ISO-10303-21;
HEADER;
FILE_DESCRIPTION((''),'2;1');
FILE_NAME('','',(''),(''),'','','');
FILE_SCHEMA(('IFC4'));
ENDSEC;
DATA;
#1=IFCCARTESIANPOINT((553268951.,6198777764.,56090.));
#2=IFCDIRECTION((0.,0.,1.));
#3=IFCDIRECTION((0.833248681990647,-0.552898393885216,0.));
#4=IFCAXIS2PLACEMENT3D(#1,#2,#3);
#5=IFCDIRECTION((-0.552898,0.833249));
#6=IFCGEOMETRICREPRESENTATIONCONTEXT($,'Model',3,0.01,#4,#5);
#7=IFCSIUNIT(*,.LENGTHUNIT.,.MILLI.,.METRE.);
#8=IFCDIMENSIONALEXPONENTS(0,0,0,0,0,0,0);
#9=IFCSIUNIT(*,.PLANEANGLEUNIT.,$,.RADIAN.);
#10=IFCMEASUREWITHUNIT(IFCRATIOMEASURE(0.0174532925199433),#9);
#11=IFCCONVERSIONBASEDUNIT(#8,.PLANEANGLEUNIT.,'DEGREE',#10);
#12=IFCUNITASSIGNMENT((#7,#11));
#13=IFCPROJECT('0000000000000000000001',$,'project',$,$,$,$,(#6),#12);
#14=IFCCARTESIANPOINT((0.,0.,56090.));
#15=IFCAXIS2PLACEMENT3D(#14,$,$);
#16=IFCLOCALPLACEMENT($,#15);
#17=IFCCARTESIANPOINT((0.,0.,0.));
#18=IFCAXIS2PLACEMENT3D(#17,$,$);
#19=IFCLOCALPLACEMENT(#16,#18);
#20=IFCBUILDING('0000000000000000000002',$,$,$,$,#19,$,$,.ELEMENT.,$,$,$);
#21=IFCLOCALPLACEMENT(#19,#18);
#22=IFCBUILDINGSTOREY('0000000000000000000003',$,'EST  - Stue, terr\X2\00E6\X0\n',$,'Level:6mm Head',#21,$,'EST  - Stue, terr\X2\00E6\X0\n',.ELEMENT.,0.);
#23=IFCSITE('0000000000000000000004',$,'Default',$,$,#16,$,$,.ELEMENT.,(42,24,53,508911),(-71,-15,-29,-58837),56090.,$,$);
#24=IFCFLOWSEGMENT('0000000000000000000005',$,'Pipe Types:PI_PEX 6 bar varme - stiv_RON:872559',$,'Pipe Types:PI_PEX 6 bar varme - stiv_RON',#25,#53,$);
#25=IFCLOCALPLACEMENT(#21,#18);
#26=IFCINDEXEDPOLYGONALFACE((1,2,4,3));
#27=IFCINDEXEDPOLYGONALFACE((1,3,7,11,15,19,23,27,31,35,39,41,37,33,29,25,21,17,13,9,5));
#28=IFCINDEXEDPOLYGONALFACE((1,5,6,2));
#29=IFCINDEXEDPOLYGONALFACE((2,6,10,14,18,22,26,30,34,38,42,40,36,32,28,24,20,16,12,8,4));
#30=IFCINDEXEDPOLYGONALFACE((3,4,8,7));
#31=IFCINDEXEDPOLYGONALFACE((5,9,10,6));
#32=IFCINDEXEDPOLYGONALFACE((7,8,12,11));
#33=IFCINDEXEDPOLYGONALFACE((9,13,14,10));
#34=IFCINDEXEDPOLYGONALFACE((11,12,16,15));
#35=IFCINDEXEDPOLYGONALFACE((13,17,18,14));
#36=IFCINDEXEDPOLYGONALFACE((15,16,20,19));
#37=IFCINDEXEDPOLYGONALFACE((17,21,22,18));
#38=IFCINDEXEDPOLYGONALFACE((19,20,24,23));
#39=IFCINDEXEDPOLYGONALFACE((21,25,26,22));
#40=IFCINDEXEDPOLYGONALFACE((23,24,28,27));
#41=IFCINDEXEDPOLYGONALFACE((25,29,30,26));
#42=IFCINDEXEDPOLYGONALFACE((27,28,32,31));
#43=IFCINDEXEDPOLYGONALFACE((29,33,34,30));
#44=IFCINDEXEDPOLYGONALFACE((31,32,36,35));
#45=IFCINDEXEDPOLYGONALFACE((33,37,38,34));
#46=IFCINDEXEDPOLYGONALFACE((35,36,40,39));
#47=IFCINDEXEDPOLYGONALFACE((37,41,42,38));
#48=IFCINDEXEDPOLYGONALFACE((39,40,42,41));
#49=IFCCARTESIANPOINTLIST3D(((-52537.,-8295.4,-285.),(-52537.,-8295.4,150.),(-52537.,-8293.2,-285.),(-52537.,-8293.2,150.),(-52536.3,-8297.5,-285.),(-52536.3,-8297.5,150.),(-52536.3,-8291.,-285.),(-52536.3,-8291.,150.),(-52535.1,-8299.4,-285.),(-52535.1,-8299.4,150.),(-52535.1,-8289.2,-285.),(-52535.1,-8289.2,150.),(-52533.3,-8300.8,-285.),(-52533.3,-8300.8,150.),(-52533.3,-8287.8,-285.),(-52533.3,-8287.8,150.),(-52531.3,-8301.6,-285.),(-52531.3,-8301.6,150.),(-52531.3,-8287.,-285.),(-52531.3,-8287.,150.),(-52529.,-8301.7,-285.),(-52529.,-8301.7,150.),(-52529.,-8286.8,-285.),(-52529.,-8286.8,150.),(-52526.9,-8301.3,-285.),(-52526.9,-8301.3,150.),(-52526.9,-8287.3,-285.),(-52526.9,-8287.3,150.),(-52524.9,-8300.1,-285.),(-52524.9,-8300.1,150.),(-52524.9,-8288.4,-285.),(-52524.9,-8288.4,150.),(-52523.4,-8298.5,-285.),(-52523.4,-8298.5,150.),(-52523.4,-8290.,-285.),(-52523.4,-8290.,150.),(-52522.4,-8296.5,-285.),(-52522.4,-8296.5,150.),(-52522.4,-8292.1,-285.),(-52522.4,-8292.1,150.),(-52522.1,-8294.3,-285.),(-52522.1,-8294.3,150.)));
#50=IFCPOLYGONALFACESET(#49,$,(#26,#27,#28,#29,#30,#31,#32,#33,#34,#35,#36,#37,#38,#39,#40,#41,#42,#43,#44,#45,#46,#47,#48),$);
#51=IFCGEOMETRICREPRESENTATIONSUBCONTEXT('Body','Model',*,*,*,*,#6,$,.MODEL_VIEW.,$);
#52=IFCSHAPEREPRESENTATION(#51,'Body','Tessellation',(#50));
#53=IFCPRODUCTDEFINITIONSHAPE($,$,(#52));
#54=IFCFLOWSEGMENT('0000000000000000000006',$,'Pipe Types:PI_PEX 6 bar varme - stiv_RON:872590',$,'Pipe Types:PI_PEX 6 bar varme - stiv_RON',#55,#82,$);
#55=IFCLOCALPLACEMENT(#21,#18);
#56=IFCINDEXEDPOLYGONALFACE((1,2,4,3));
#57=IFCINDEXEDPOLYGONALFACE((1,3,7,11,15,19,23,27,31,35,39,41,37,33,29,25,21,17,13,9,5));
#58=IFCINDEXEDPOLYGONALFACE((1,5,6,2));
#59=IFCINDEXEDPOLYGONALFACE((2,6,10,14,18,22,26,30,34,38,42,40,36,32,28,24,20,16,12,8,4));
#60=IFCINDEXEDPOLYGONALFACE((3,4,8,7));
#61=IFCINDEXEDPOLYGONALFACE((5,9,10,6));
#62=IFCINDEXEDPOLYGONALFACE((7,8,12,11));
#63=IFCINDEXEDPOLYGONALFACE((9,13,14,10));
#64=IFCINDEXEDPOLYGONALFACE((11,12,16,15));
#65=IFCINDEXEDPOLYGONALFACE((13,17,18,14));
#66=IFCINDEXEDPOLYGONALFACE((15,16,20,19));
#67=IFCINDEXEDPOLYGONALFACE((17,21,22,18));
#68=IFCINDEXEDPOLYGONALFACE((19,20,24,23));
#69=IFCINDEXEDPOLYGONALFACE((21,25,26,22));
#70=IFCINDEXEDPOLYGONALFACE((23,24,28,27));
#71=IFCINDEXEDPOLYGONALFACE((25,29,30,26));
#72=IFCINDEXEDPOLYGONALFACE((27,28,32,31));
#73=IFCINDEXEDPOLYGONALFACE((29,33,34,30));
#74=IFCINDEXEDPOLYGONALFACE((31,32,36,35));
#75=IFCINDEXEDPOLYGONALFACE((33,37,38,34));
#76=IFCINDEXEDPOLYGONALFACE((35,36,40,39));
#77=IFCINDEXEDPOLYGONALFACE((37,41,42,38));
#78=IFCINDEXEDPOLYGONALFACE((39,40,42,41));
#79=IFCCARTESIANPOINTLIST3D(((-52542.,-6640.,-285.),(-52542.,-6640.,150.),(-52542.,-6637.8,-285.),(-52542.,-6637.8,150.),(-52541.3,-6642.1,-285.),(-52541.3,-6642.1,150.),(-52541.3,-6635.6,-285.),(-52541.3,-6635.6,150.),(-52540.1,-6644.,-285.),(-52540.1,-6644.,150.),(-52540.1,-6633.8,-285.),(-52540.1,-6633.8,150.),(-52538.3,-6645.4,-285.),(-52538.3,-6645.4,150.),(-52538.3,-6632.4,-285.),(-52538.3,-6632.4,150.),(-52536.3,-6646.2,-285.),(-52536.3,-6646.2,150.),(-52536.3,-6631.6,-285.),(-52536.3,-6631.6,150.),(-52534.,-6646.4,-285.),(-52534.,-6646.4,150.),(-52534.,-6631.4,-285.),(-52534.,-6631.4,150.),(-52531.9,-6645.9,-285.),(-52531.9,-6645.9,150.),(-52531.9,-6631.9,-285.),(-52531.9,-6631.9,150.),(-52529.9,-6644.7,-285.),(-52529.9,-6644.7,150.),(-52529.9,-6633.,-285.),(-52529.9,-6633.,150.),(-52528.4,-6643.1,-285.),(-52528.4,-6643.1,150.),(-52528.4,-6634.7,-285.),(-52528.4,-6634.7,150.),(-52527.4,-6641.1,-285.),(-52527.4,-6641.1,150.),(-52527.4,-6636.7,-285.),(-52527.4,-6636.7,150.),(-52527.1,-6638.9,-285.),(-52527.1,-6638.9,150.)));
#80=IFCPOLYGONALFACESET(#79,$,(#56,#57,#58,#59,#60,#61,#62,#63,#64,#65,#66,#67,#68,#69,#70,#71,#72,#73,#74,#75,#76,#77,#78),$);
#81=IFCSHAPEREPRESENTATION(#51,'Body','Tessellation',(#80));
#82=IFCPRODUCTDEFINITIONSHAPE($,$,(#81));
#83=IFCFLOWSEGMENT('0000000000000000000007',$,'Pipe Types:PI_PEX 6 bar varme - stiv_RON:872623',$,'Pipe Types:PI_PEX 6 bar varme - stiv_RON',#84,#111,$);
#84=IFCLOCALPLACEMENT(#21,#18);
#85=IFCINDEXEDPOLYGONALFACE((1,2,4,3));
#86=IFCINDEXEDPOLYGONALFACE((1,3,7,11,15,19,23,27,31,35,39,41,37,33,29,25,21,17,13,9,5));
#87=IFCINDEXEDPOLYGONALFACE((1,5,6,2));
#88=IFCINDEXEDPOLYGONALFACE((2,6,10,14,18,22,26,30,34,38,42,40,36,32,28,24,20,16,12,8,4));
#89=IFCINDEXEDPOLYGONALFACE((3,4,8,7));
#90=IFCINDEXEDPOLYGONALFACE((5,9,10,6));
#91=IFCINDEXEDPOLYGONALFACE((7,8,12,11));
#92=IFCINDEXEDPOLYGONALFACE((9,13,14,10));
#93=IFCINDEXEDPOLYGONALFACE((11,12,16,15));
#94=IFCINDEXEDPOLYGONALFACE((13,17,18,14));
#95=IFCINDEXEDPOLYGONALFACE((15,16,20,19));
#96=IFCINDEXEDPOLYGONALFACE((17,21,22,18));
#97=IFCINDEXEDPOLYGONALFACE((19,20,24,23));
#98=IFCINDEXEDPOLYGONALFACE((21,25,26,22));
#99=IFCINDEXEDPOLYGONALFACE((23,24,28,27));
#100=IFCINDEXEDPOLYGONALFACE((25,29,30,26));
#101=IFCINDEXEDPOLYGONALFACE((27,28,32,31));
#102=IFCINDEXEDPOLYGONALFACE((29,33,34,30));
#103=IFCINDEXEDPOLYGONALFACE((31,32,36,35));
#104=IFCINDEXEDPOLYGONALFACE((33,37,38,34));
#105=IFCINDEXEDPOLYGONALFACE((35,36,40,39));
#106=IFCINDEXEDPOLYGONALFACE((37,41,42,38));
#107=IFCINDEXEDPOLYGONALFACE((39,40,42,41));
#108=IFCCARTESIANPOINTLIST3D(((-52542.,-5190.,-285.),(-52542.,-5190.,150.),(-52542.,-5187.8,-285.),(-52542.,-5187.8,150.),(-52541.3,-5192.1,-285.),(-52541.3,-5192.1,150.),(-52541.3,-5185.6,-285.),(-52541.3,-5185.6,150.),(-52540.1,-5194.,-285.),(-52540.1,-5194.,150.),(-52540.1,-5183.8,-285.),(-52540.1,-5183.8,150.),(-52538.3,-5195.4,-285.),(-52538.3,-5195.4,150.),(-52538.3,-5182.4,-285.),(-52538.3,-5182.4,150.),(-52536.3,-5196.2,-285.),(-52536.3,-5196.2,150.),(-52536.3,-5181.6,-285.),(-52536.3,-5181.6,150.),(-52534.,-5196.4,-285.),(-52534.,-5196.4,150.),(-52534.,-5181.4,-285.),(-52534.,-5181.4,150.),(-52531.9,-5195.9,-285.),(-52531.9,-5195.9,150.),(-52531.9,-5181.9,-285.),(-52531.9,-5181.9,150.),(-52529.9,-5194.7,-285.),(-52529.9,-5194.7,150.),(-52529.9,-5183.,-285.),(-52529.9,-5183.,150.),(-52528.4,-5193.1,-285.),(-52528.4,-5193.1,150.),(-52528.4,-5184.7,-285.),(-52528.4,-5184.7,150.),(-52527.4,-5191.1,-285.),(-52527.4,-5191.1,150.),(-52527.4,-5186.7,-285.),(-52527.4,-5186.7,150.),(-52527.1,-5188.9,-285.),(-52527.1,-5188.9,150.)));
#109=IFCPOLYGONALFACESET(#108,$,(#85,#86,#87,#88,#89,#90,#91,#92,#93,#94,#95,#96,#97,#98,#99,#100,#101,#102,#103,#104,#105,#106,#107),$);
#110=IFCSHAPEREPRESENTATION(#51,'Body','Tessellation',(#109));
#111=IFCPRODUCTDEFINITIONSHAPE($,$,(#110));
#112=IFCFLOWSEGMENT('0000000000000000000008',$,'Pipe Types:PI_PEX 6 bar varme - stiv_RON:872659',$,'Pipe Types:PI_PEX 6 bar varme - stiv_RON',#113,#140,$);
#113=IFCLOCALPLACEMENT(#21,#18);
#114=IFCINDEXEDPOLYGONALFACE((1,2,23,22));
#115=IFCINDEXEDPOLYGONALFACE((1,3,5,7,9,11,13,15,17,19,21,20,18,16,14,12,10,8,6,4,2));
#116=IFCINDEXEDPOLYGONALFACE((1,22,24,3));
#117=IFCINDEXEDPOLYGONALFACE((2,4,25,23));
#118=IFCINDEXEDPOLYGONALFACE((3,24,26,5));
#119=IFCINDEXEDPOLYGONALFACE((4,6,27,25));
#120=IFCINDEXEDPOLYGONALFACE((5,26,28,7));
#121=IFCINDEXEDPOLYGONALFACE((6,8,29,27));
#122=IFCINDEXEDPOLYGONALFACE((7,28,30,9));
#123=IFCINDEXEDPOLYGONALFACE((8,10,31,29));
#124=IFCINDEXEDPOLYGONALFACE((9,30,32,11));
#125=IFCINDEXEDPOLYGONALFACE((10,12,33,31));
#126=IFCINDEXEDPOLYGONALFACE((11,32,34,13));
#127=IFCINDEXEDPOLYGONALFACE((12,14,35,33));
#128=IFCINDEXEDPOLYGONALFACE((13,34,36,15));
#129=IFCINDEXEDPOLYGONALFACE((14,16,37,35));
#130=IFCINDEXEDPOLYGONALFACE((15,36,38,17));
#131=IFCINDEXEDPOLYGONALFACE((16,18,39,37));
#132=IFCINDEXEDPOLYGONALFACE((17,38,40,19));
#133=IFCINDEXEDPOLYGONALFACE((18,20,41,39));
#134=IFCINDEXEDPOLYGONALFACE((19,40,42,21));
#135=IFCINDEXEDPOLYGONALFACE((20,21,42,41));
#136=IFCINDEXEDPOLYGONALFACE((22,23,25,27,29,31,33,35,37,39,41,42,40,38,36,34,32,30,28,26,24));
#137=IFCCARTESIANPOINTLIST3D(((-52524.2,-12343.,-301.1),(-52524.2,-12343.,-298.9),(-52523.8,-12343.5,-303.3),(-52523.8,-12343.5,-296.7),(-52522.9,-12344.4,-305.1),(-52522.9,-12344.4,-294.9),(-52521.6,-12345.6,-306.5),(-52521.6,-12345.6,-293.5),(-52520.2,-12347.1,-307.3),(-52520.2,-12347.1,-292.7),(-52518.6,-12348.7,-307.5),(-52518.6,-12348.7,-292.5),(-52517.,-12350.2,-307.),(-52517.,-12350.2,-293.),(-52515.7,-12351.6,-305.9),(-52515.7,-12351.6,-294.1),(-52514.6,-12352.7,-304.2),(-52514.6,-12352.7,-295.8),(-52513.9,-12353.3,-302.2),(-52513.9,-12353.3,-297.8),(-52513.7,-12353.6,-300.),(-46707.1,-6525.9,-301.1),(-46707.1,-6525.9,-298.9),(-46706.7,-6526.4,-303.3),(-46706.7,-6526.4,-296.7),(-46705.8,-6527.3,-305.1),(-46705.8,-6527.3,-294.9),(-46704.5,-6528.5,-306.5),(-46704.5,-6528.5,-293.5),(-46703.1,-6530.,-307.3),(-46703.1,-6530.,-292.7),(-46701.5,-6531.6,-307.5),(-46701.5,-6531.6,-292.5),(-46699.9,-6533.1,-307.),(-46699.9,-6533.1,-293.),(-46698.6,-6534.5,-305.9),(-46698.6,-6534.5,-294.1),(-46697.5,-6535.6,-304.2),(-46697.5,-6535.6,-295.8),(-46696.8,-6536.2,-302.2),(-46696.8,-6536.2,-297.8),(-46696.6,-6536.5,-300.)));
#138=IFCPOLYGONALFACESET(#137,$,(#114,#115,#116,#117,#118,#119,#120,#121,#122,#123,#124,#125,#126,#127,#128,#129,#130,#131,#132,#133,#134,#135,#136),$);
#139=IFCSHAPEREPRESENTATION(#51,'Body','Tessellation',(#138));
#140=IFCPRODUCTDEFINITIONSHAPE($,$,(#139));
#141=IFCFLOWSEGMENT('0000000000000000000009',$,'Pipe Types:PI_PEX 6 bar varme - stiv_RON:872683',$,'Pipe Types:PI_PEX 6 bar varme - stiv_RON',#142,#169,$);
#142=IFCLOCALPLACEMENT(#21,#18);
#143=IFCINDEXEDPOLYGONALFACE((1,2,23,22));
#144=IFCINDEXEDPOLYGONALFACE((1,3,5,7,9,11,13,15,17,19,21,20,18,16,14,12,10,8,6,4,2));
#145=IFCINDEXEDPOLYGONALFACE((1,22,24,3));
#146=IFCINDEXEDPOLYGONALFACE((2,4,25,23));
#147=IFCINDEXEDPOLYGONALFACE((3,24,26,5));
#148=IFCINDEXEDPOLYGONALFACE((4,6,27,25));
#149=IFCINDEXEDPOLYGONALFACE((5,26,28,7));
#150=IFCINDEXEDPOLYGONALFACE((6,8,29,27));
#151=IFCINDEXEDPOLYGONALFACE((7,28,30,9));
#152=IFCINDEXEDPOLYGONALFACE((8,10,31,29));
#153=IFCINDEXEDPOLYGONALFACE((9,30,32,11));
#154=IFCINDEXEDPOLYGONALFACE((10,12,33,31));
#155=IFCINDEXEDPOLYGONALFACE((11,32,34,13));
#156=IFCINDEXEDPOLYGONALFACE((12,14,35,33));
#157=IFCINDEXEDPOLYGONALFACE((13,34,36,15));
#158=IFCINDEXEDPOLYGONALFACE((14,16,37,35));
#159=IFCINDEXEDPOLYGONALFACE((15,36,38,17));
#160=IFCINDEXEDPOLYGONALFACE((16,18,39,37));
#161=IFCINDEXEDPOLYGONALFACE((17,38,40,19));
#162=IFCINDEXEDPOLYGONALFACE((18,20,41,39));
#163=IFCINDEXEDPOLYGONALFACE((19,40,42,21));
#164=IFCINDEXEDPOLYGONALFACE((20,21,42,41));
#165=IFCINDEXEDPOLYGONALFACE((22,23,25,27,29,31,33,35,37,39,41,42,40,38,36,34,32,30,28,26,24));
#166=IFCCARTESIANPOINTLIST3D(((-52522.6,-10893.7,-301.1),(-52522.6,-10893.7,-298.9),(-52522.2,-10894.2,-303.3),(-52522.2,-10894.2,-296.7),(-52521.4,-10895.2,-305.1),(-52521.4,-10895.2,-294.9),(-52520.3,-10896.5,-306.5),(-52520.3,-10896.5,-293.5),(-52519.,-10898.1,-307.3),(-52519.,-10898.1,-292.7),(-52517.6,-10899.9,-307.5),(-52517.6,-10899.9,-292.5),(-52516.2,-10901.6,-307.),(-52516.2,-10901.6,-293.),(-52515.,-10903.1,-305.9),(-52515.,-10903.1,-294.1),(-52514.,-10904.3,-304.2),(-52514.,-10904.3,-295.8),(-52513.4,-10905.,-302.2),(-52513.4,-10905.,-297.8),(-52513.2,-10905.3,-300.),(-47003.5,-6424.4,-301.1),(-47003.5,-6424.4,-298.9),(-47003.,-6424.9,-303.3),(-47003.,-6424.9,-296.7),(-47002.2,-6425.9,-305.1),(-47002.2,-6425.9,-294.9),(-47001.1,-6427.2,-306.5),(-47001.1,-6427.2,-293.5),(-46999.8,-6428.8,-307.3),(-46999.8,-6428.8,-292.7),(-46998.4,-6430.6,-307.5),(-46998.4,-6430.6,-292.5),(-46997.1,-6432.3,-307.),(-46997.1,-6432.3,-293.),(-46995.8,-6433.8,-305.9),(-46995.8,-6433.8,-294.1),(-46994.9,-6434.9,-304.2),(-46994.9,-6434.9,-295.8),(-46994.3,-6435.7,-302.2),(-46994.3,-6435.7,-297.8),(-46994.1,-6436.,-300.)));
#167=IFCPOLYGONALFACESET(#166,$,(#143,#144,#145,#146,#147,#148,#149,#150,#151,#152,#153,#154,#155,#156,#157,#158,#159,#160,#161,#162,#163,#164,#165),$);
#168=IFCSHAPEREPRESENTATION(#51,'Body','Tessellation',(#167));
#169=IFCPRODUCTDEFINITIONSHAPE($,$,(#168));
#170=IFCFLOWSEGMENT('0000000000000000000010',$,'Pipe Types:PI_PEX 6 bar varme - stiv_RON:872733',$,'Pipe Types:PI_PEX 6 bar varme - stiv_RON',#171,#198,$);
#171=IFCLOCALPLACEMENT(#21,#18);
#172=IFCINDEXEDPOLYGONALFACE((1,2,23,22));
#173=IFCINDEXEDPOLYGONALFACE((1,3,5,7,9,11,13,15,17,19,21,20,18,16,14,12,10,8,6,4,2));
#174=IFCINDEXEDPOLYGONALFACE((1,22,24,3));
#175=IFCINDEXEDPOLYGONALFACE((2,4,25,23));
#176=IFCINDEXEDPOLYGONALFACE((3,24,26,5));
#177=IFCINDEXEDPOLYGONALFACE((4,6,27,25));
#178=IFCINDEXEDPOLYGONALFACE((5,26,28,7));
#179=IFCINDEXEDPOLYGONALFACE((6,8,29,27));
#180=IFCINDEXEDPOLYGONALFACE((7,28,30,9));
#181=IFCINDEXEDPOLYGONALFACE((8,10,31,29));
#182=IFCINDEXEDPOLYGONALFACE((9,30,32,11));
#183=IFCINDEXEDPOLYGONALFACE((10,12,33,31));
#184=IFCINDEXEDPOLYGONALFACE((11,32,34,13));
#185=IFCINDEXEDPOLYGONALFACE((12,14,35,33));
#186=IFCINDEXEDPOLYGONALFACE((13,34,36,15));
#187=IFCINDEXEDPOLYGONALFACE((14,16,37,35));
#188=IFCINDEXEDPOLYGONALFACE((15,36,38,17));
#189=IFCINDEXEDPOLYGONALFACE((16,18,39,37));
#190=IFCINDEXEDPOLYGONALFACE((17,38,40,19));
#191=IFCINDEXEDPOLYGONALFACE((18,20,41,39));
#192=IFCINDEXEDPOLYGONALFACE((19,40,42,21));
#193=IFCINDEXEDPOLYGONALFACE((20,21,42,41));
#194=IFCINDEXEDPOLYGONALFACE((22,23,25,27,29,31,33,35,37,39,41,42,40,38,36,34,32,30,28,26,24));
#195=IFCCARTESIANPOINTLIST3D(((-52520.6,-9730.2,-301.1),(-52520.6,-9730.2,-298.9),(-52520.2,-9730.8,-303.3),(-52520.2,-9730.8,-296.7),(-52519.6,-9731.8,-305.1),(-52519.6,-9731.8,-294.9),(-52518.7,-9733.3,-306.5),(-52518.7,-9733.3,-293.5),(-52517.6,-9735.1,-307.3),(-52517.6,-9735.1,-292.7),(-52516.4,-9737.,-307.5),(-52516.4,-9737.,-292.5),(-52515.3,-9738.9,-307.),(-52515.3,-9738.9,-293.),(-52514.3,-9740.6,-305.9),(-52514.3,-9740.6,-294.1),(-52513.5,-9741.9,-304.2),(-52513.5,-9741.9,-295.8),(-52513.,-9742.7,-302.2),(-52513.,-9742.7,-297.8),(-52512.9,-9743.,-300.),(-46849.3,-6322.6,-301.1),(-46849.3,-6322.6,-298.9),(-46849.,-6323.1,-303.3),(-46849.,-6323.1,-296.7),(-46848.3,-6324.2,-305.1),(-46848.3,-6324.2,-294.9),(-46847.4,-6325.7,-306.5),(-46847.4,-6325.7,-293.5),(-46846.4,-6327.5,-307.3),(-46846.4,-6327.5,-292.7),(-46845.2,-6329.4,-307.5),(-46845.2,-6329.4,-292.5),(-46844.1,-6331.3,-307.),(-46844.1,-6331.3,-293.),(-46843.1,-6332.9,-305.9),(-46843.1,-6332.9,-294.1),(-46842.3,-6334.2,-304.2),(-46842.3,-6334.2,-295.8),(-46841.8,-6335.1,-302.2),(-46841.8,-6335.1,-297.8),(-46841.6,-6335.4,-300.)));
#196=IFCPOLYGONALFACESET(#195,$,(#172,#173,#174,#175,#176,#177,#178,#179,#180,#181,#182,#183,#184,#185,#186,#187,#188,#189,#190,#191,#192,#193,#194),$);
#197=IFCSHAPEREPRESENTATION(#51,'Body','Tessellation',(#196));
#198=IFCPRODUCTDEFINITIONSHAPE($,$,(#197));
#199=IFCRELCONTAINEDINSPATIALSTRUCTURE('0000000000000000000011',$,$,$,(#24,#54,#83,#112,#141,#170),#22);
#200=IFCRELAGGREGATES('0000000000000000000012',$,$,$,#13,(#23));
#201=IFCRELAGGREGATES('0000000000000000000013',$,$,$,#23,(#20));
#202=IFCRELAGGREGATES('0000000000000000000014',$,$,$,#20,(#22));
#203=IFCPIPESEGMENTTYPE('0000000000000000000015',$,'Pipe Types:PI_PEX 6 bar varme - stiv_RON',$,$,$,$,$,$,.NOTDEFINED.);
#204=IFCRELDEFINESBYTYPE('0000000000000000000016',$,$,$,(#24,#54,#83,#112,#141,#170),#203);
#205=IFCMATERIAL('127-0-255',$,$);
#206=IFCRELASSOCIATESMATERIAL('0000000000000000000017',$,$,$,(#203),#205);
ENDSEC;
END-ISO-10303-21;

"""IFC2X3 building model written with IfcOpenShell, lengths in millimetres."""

from ifc_helpers import new_model, entity, si_unit, converted_unit, direction, frame, origin, origin_2d_with_axis, place, context, subcontext, project, spatial, circle, extrude, material, type_object, element, save


model = new_model("IFC2X3")

# Units and contexts
model_context = context("Model", 3, precision=0.01, world=frame((553268951.0, 6198777764.0, 56090.0), z_axis=(0.0, 0.0, 1.0), x_axis=(0.833248681990647, -0.552898393885216, 0.0)), true_north=direction((-0.552898, 0.833249)))
body_context = subcontext(model_context, "Body", "Model", "MODEL_VIEW")
ifc_project = project(units=[si_unit("LENGTHUNIT", "METRE", prefix="MILLI"), converted_unit("PLANEANGLEUNIT", "DEGREE", entity("IfcRatioMeasure", 0.0174532925199433), si_unit("PLANEANGLEUNIT", "RADIAN"), dimensions=[0, 0, 0, 0, 0, 0, 0])], contexts=[model_context])

# Site, building, storey
site_placement = place(None, frame((0.0, 0.0, 56090.0)))
site = spatial("IfcSite", under=ifc_project, at=site_placement, Name="Default", CompositionType="ELEMENT", RefLatitude=(42, 24, 53, 508911), RefLongitude=(-71, -15, -29, -58837), RefElevation=56090.0)
building_placement = place(site_placement, origin())
building = spatial("IfcBuilding", under=site, at=building_placement, CompositionType="ELEMENT")
storey_placement = place(building_placement, frame((0.0, 0.0, 0.0)))
storey = spatial("IfcBuildingStorey", under=building, at=storey_placement, Name="EST  - Stue, terræn", ObjectType="Level:6mm Head", LongName="EST  - Stue, terræn", CompositionType="ELEMENT", Elevation=0.0)

# Flow segments
ifc_material = material(Name="127-0-255")
pipe_segment_type = type_object("IfcPipeSegmentType", Name="Pipe Types:PI_PEX 6 bar varme - stiv_RON", PredefinedType="NOTDEFINED", material=ifc_material)
flow_segment_1_placement = place(storey_placement, origin())
element("IfcFlowSegment", 1, at=flow_segment_1_placement, inside=storey, type_object=pipe_segment_type, Name="Pipe Types:PI_PEX 6 bar varme - stiv_RON:872559", ObjectType="Pipe Types:PI_PEX 6 bar varme - stiv_RON", context=body_context, shape_type="SweptSolid", body=[
    extrude(circle(Radius=7.5, at=origin_2d_with_axis()), frame((-52529.6, -8294.3, -285.0)), (0.0, 0.0, 1.0), 435.0),
])
flow_segment_2_placement = place(storey_placement, origin())
element("IfcFlowSegment", 2, at=flow_segment_2_placement, inside=storey, type_object=pipe_segment_type, Name="Pipe Types:PI_PEX 6 bar varme - stiv_RON:872590", ObjectType="Pipe Types:PI_PEX 6 bar varme - stiv_RON", context=body_context, shape_type="SweptSolid", body=[
    extrude(circle(Radius=7.5, at=origin_2d_with_axis()), frame((-52534.6, -6638.9, -285.0)), (0.0, 0.0, 1.0), 435.0),
])
flow_segment_3_placement = place(storey_placement, origin())
element("IfcFlowSegment", 3, at=flow_segment_3_placement, inside=storey, type_object=pipe_segment_type, Name="Pipe Types:PI_PEX 6 bar varme - stiv_RON:872623", ObjectType="Pipe Types:PI_PEX 6 bar varme - stiv_RON", context=body_context, shape_type="SweptSolid", body=[
    extrude(circle(Radius=7.5, at=origin_2d_with_axis()), frame((-52534.6, -5188.9, -285.0)), (0.0, 0.0, 1.0), 435.0),
])
flow_segment_4_placement = place(storey_placement, origin())
element("IfcFlowSegment", 4, at=flow_segment_4_placement, inside=storey, type_object=pipe_segment_type, Name="Pipe Types:PI_PEX 6 bar varme - stiv_RON:872659", ObjectType="Pipe Types:PI_PEX 6 bar varme - stiv_RON", context=body_context, shape_type="SweptSolid", body=[
    extrude(circle(Radius=7.5, at=origin_2d_with_axis()), frame((-52519.0, -12348.3, -300.0), z_axis=(0.707107, 0.707107, 0.0), x_axis=(0.707107, -0.707107, 0.0)), (0.0, 0.0, 1.0), 8226.6),
])
flow_segment_5_placement = place(storey_placement, origin())
element("IfcFlowSegment", 5, at=flow_segment_5_placement, inside=storey, type_object=pipe_segment_type, Name="Pipe Types:PI_PEX 6 bar varme - stiv_RON:872683", ObjectType="Pipe Types:PI_PEX 6 bar varme - stiv_RON", context=body_context, shape_type="SweptSolid", body=[
    extrude(circle(Radius=7.5, at=origin_2d_with_axis()), frame((-52517.9, -10899.4, -300.0), z_axis=(0.777146, 0.62932, 0.0), x_axis=(0.62932, -0.777146, 0.0)), (0.0, 0.0, 1.0), 7101.8),
])
flow_segment_6_placement = place(storey_placement, origin())
element("IfcFlowSegment", 6, at=flow_segment_6_placement, inside=storey, type_object=pipe_segment_type, Name="Pipe Types:PI_PEX 6 bar varme - stiv_RON:872733", ObjectType="Pipe Types:PI_PEX 6 bar varme - stiv_RON", context=body_context, shape_type="SweptSolid", body=[
    extrude(circle(Radius=7.5, at=origin_2d_with_axis()), frame((-52516.7, -9736.5, -300.0), z_axis=(0.857167, 0.515038, 0.0), x_axis=(0.515038, -0.857167, 0.0)), (0.0, 0.0, 1.0), 6616.2),
])

save(model, "model.ifc")
